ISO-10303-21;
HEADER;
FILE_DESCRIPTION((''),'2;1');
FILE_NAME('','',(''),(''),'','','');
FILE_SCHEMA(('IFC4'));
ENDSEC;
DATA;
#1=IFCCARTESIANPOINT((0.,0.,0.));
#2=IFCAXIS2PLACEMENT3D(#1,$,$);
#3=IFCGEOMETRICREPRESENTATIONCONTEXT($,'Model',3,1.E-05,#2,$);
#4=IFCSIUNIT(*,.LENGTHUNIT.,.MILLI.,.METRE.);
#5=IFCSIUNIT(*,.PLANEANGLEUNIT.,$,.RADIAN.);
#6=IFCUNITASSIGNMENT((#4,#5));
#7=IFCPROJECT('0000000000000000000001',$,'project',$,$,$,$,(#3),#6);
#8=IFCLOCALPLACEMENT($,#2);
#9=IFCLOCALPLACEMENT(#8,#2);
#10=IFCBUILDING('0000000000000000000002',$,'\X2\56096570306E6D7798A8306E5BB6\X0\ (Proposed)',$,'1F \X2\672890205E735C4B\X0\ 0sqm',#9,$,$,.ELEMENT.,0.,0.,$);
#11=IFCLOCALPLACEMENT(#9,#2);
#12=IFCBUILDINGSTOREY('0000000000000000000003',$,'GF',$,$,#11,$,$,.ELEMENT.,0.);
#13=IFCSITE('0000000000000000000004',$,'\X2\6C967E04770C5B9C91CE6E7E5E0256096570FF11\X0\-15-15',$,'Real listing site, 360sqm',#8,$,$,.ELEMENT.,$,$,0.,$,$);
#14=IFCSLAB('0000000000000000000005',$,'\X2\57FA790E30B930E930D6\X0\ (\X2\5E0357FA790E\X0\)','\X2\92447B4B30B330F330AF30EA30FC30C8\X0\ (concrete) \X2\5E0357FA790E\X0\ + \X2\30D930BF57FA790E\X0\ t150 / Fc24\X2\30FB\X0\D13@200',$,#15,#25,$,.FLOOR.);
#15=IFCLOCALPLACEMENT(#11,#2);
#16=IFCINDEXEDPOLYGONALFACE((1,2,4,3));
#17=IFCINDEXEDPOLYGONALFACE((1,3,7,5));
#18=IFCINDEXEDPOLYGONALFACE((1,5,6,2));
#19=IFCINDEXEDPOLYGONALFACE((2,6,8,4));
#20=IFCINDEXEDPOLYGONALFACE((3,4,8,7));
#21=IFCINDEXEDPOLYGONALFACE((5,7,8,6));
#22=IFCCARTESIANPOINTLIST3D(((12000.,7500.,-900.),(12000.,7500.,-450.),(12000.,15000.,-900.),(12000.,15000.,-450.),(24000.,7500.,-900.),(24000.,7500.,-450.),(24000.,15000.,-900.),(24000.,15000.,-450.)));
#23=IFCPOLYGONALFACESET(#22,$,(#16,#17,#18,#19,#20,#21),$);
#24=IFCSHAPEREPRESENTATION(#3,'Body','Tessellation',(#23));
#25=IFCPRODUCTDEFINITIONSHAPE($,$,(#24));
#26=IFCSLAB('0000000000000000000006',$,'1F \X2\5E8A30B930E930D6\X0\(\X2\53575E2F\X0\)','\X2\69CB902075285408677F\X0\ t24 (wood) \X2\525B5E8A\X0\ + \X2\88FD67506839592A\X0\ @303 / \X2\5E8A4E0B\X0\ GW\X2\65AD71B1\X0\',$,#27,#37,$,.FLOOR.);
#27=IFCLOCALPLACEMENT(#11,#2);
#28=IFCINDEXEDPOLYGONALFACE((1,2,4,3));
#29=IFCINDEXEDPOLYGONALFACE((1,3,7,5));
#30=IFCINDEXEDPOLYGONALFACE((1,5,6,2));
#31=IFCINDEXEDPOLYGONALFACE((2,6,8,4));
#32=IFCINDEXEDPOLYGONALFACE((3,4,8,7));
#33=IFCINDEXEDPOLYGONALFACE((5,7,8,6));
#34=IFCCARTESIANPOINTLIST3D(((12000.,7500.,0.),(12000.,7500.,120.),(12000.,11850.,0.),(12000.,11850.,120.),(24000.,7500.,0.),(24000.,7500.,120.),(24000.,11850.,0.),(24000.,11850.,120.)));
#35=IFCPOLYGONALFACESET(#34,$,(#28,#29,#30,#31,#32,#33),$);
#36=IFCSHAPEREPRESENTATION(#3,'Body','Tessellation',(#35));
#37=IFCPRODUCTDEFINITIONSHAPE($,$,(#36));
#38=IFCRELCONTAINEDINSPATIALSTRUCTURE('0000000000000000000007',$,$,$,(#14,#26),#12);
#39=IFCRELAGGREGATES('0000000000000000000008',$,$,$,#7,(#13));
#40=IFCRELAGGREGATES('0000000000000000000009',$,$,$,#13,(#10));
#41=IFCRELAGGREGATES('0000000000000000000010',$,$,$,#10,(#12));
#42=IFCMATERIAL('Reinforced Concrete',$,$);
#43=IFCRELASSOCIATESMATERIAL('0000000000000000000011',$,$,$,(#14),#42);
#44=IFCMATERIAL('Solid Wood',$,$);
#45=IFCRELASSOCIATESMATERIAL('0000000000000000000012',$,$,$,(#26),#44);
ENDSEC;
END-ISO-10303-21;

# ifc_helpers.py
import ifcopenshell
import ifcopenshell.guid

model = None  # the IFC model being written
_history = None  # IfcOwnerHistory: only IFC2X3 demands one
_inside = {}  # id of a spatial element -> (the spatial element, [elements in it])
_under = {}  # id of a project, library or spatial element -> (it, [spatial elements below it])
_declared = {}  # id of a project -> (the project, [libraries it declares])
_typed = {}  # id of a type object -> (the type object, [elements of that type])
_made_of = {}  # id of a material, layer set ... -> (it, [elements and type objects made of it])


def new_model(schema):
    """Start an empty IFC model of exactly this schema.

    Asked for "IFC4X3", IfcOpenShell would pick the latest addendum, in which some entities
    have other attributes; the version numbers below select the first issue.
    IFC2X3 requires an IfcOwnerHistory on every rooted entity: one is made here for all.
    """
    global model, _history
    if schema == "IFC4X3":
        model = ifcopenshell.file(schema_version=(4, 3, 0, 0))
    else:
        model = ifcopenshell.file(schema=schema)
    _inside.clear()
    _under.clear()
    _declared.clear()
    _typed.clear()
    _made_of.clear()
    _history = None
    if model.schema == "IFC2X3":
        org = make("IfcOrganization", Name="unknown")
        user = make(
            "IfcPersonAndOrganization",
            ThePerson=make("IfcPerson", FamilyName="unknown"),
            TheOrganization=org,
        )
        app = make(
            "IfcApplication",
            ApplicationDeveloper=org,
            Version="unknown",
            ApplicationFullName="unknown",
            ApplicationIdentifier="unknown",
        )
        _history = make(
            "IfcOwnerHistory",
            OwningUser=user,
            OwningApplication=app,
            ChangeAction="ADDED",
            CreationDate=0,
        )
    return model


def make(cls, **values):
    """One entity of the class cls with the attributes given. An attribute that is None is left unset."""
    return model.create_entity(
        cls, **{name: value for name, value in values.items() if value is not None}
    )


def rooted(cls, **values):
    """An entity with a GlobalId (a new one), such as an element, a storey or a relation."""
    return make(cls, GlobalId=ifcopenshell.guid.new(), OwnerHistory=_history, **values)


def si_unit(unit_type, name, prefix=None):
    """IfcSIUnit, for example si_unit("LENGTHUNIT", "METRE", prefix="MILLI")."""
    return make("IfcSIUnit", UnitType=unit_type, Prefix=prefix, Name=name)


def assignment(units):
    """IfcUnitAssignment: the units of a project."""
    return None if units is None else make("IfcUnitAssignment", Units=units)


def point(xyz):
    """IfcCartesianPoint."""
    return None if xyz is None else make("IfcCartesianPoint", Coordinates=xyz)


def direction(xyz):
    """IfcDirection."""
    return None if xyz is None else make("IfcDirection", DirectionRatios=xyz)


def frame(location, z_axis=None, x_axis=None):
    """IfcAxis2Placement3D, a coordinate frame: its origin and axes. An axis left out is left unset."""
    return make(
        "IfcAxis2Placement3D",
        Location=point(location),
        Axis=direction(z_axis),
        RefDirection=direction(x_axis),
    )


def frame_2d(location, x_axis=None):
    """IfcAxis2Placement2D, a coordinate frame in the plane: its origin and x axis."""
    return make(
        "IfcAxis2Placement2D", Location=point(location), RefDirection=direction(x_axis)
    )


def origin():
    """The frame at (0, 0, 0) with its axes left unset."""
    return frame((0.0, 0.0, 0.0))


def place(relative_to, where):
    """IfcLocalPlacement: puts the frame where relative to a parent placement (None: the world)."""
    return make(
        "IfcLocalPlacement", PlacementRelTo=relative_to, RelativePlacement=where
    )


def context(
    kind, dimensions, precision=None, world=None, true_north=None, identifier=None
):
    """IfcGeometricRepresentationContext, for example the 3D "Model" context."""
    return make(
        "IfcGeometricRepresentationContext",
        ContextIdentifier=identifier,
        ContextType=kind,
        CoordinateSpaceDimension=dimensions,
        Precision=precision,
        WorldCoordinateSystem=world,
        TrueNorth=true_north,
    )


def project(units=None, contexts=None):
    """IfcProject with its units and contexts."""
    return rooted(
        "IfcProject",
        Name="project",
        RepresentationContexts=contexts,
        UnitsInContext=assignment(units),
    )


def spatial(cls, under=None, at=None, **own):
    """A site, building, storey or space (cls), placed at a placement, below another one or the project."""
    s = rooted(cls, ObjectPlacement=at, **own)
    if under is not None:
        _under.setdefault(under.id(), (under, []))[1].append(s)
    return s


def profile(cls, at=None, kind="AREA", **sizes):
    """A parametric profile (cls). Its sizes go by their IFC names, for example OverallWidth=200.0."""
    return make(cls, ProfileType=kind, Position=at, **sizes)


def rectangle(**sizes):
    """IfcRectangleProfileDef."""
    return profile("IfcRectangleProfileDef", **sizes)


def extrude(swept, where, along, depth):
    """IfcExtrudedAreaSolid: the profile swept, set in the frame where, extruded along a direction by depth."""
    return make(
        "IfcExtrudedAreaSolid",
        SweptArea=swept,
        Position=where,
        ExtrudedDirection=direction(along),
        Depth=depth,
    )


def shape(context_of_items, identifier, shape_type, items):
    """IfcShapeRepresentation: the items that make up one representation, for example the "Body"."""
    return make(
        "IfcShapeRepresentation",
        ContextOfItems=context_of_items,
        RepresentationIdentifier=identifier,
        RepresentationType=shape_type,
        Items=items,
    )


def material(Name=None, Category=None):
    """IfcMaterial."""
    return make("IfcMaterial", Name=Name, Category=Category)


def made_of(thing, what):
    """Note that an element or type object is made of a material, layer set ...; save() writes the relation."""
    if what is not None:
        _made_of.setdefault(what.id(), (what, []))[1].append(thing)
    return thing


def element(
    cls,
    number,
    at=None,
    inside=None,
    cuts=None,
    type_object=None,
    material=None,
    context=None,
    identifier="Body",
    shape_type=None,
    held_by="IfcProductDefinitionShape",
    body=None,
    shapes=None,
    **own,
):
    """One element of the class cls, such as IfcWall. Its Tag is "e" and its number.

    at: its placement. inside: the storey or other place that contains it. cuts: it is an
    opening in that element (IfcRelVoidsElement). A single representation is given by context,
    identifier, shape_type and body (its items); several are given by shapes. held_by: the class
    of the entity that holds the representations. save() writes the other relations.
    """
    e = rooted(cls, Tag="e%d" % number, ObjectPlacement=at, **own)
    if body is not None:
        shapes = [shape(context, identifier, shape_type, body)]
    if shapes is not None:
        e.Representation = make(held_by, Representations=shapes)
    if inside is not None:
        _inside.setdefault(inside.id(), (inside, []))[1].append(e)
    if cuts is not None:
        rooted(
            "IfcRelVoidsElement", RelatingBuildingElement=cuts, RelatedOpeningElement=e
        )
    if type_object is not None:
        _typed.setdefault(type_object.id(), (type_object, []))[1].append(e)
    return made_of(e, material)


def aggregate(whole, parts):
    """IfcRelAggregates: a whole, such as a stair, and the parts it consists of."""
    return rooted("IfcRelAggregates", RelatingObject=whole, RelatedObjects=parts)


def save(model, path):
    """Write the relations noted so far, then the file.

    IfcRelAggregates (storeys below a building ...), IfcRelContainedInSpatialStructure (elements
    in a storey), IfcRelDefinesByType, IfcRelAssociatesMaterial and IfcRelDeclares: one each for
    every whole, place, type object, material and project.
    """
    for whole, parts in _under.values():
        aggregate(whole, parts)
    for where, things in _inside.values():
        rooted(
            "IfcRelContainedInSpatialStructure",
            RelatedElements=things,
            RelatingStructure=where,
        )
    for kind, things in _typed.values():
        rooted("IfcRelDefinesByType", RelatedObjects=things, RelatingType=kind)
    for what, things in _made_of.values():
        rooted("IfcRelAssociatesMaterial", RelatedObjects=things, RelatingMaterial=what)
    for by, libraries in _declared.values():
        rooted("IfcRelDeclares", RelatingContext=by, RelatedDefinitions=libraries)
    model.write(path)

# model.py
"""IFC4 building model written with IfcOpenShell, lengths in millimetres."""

from ifc_helpers import new_model, si_unit, frame, frame_2d, origin, place, context, project, spatial, rectangle, extrude, material, element, save


model = new_model("IFC4")

# Units and contexts
model_context = context("Model", 3, precision=1e-05, world=origin())
ifc_project = project(units=[si_unit("LENGTHUNIT", "METRE", prefix="MILLI"), si_unit("PLANEANGLEUNIT", "RADIAN")], contexts=[model_context])

# Site, building, storey
site_placement = place(None, origin())
site = spatial("IfcSite", under=ifc_project, at=site_placement, Name="沖縄県宜野湾市嘉数１-15-15", ObjectType="Real listing site, 360sqm", CompositionType="ELEMENT", RefElevation=0.0)
building_placement = place(site_placement, origin())
building = spatial("IfcBuilding", under=site, at=building_placement, Name="嘉数の海風の家 (Proposed)", ObjectType="1F 木造平屋 0sqm", CompositionType="ELEMENT", ElevationOfRefHeight=0.0, ElevationOfTerrain=0.0)
storey_placement = place(building_placement, origin())
storey = spatial("IfcBuildingStorey", under=building, at=storey_placement, Name="GF", CompositionType="ELEMENT", Elevation=0.0)

# Slabs
ifc_material_1 = material(Name="Reinforced Concrete")
slab_1_placement = place(storey_placement, frame((6000.0, 3750.0, -450.0)))
element("IfcSlab", 1, at=slab_1_placement, inside=storey, material=ifc_material_1, Name="基礎スラブ (布基礎)", Description="鉄筋コンクリート (concrete) 布基礎 + ベタ基礎 t150 / Fc24・D13@200", PredefinedType="FLOOR", context=model_context, shape_type="SweptSolid", body=[
    extrude(rectangle(XDim=12000.0, YDim=7500.0, at=frame_2d((6000.0, 3750.0))), frame((6000.0, 3750.0, -450.0)), (0.0, 0.0, 1.0), 450.0),
])
ifc_material_2 = material(Name="Solid Wood")
slab_2_placement = place(storey_placement, frame((6000.0, 3750.0, 0.0)))
element("IfcSlab", 2, at=slab_2_placement, inside=storey, material=ifc_material_2, Name="1F 床スラブ(南帯)", Description="構造用合板 t24 (wood) 剛床 + 製材根太 @303 / 床下 GW断熱", PredefinedType="FLOOR", context=model_context, shape_type="SweptSolid", body=[
    extrude(rectangle(XDim=12000.0, YDim=4350.0, at=frame_2d((6000.0, 2175.0))), frame((6000.0, 3750.0, 0.0)), (0.0, 0.0, 1.0), 120.0),
])

save(model, "model.ifc")
